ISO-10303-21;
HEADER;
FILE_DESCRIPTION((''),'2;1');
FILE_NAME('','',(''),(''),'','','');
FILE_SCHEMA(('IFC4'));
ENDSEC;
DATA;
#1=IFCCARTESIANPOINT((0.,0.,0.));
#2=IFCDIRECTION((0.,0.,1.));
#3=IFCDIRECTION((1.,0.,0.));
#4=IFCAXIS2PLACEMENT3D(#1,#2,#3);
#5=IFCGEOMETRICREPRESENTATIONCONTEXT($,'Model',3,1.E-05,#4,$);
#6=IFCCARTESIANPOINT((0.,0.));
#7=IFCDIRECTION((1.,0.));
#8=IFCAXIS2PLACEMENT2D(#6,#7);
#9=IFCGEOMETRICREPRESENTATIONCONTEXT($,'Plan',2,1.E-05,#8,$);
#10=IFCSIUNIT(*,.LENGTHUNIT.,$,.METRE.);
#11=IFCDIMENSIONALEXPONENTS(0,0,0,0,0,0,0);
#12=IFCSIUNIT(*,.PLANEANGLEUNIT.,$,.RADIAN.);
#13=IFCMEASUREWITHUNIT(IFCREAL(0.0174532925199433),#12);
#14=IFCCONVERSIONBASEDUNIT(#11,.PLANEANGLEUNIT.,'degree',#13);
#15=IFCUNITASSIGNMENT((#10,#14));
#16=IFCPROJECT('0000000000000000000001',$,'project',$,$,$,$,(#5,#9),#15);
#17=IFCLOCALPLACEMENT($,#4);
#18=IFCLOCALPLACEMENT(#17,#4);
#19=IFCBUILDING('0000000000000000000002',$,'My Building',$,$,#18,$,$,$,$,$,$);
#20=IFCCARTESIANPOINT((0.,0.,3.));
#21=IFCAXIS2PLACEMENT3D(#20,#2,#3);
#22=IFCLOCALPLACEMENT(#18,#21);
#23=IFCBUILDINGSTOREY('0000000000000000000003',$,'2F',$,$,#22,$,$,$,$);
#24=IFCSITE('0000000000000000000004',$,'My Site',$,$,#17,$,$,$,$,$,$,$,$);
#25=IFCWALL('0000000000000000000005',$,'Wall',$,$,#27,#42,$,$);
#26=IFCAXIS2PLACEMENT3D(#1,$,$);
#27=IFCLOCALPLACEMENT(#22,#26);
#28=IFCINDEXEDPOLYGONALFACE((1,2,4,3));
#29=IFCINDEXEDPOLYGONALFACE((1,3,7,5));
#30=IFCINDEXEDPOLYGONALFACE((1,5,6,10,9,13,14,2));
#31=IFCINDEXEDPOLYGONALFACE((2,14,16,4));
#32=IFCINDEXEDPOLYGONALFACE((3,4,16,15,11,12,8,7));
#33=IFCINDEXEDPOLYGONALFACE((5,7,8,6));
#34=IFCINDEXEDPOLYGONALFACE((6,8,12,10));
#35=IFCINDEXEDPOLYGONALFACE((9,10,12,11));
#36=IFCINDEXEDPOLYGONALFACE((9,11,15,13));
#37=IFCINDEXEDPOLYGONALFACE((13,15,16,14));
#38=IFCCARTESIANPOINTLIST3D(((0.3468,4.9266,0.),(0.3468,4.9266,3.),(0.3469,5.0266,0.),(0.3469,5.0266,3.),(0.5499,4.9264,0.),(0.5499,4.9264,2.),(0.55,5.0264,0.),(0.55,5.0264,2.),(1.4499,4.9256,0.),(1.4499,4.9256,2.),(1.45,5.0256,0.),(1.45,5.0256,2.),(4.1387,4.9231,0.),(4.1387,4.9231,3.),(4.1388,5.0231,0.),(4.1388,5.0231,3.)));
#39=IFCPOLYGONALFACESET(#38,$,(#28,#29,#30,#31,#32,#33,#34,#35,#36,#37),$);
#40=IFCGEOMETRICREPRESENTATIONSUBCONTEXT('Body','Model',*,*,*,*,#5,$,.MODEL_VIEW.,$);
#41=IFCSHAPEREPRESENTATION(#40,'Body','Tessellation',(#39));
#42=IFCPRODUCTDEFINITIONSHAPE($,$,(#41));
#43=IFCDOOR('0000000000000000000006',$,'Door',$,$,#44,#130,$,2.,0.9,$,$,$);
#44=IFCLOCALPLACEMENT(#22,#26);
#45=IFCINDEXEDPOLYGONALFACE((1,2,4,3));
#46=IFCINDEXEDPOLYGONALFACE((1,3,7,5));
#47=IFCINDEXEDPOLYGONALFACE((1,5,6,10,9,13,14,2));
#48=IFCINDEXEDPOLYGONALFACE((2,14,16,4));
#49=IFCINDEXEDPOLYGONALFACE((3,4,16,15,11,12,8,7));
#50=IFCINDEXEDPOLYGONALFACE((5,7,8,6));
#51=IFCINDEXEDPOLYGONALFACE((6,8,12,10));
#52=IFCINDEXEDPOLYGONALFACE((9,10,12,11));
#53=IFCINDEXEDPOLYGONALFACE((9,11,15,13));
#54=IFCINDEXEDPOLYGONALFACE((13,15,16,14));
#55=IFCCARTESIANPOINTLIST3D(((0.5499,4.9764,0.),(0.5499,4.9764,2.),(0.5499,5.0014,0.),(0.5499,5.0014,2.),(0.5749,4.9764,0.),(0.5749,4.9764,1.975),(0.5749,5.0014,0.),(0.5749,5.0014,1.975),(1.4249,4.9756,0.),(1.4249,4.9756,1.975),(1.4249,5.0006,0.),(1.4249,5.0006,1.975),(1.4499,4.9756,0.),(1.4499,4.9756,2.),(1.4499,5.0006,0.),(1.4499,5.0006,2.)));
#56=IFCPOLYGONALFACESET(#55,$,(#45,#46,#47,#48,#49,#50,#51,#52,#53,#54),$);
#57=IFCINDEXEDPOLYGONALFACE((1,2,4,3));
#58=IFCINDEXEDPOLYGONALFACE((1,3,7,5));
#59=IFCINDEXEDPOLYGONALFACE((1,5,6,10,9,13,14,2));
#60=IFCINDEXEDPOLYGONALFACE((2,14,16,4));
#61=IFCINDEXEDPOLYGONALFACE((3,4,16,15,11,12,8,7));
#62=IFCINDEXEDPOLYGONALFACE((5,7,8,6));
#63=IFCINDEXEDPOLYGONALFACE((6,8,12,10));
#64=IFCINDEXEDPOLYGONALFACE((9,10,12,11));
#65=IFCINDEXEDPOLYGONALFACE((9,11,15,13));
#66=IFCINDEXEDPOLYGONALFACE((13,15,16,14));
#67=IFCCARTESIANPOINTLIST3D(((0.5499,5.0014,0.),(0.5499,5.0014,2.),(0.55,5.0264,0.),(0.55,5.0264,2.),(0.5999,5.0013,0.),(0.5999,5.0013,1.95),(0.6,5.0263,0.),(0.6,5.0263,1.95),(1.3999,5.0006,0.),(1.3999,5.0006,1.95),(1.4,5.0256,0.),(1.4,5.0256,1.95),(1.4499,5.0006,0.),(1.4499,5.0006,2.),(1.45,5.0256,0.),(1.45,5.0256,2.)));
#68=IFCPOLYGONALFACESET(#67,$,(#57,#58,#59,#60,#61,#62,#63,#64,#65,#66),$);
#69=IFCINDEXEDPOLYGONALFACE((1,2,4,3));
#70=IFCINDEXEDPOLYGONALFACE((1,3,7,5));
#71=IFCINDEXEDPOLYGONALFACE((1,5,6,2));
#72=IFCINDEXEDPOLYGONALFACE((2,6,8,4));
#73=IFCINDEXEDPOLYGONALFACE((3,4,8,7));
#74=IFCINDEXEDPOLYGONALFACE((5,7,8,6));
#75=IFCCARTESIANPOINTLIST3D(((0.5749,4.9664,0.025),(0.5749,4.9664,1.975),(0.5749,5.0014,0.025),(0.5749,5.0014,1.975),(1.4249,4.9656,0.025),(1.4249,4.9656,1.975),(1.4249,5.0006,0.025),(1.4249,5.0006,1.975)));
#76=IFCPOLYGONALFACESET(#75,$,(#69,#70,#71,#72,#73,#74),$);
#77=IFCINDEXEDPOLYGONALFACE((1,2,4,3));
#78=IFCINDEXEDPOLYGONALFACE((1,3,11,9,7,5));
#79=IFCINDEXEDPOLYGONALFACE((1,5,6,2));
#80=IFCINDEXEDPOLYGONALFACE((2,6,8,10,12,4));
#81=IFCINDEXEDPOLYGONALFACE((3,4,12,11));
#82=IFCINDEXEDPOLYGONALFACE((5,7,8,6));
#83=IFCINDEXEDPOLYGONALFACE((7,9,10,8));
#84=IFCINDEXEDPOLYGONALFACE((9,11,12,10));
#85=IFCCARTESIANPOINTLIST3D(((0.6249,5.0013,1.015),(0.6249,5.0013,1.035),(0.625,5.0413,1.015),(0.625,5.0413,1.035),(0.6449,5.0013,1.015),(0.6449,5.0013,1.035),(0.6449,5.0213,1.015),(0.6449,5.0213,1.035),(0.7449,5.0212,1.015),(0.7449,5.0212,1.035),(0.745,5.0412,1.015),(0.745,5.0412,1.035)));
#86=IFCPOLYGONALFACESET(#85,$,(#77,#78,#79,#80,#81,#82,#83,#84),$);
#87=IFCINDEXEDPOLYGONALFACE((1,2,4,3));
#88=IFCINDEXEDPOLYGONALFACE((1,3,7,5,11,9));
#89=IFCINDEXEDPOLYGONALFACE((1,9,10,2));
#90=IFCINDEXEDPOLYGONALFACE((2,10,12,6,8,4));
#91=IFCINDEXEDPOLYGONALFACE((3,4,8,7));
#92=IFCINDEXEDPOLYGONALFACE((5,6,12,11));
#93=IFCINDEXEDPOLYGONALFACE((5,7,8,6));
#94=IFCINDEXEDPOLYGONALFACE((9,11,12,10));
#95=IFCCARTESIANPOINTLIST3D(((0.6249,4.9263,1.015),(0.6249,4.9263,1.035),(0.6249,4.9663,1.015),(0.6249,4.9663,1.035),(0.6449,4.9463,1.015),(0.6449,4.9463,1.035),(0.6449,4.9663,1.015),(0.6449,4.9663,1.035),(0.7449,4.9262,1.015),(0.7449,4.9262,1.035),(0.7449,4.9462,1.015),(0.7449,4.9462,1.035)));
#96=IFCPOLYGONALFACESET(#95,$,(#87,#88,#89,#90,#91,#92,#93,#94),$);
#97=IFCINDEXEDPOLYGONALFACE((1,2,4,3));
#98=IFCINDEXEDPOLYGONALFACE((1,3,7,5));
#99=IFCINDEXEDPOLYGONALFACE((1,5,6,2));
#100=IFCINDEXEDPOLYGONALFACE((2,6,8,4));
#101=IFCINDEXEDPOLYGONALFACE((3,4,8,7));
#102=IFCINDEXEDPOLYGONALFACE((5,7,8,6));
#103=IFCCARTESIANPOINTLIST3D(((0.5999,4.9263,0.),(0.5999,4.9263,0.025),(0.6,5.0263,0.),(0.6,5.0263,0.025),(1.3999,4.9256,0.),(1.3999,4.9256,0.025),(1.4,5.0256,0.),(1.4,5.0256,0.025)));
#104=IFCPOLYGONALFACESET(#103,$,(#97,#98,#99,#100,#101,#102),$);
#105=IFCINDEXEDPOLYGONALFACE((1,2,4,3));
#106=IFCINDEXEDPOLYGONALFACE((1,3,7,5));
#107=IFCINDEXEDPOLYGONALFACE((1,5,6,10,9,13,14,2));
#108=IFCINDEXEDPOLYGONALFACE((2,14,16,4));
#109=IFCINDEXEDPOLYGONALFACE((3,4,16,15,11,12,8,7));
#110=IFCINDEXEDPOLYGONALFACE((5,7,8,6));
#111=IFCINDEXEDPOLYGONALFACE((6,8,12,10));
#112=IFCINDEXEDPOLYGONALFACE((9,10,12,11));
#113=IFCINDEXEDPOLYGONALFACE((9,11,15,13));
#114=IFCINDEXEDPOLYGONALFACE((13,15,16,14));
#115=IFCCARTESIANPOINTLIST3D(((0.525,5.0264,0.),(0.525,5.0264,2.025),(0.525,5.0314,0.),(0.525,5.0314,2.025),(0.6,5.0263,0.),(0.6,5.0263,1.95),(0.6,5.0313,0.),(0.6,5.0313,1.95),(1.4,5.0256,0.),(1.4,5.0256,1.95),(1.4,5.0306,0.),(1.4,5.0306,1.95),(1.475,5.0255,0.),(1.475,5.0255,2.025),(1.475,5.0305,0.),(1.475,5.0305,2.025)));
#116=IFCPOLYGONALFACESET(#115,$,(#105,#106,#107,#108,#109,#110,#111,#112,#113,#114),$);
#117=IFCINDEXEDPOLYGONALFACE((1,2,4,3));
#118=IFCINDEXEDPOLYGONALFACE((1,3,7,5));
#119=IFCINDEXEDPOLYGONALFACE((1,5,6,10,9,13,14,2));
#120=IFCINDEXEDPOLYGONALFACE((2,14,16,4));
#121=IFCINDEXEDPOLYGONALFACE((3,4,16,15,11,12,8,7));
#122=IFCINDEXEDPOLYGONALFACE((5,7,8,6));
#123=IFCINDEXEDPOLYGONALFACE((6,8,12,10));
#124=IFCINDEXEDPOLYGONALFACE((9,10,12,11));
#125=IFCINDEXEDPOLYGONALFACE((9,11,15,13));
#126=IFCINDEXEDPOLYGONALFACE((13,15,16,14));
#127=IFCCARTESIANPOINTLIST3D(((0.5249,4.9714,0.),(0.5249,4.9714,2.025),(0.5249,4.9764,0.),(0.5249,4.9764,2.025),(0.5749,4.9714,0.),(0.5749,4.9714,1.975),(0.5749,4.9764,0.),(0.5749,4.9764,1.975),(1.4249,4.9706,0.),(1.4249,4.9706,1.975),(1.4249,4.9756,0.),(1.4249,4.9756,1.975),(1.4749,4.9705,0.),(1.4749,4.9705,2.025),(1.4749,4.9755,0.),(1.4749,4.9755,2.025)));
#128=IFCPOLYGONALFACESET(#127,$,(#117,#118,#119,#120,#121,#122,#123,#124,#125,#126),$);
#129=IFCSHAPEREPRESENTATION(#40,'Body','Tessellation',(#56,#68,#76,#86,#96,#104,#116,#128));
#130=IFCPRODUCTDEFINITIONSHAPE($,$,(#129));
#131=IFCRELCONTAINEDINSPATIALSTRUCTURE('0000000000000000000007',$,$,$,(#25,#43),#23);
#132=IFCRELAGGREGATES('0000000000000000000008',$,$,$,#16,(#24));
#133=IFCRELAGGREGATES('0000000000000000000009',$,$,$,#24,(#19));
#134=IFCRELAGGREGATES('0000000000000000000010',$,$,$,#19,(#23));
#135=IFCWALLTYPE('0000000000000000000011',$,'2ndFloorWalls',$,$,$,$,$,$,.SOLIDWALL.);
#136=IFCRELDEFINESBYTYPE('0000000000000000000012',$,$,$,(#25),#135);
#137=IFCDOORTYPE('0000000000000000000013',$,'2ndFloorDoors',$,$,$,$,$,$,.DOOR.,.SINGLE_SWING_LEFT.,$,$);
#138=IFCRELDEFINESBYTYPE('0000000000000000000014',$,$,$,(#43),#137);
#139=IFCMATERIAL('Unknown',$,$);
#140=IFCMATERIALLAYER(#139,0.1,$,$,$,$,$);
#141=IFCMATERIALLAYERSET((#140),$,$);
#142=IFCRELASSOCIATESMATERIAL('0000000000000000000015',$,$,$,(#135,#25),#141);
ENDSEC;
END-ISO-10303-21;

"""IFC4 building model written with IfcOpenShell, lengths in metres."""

from ifc_helpers import new_model, entity, si_unit, converted_unit, frame, origin_with_axes, origin_2d_with_axis, place, context, subcontext, project, spatial, line, indexed_curve, outline, extrude, shape, source, transform, mapped, material, layer, layer_set, layer_usage, type_object, type_shapes, element, fill, save


model = new_model("IFC4")

# Units and contexts
model_context = context("Model", 3, precision=1e-05, world=origin_with_axes())
plan_context = context("Plan", 2, precision=1e-05, world=origin_2d_with_axis())
body_context_1 = subcontext(model_context, "Body", "Model", "MODEL_VIEW")
body_context_2 = subcontext(plan_context, "Body", "Plan", "PLAN_VIEW")
ifc_project = project(units=[si_unit("LENGTHUNIT", "METRE"), converted_unit("PLANEANGLEUNIT", "degree", entity("IfcReal", 0.0174532925199433), si_unit("PLANEANGLEUNIT", "RADIAN"), dimensions=[0, 0, 0, 0, 0, 0, 0])], contexts=[model_context, plan_context])

# Site, building, storey
site_placement = place(None, origin_with_axes())
site = spatial("IfcSite", under=ifc_project, at=site_placement, Name="My Site")
building_placement = place(site_placement, origin_with_axes())
building = spatial("IfcBuilding", under=site, at=building_placement, Name="My Building")
storey_placement = place(building_placement, frame((0.0, 0.0, 3.0), z_axis=(0.0, 0.0, 1.0), x_axis=(1.0, 0.0, 0.0)))
storey = spatial("IfcBuildingStorey", under=building, at=storey_placement, Name="2F")

# Shared definitions
ifc_material = material(Name="Unknown")

# Shared definitions
ifc_layer_1 = layer(ifc_material, 0.1)
ifc_layer_set_1 = layer_set([ifc_layer_1])
wall_type = type_object("IfcWallType", Name="2ndFloorWalls", PredefinedType="SOLIDWALL", material=ifc_layer_set_1)

# Shared definitions
shared_shape_1 = source(origin_with_axes(), body_context_1, "Body", "SweptSolid", [
    extrude(outline(indexed_curve([(0.0, 0.0), (0.9, 0.0), (0.9, 2.0), (0.0, 2.0)], segments=[line(1, 2, 3, 4, 1)])), frame((0.0, -0.6, 0.0), z_axis=(0.0, -1.0, 0.0), x_axis=(1.0, 0.0, 0.0)), (0.0, 0.0, -1.0), 1.2),
])
door_type = type_object("IfcDoorType", Name="2ndFloorDoors", OperationType="SINGLE_SWING_LEFT", PredefinedType="DOOR")
shared_shape_2 = source(origin_with_axes(), body_context_1, "Body", "SweptSolid", [
    extrude(outline(indexed_curve([(0.0, 0.0), (0.0, 2.0), (0.9, 2.0), (0.9, 0.0), (0.875, 0.0), (0.875, 1.975), (0.025, 1.975), (0.025, 0.0)], segments=[line(1, 2, 3, 4, 5, 6, 7, 8, 1)])), frame((0.0, 0.025, 0.0), z_axis=(0.0, -1.0, 0.0), x_axis=(1.0, 0.0, 0.0)), (0.0, 0.0, -1.0), 0.025),
    extrude(outline(indexed_curve([(0.0, 0.0), (0.0, 2.0), (0.9, 2.0), (0.9, 0.0), (0.85, 0.0), (0.85, 1.95), (0.05, 1.95), (0.05, 0.0)], segments=[line(1, 2, 3, 4, 5, 6, 7, 8, 1)])), frame((0.0, 0.0, 0.0), z_axis=(0.0, -1.0, 0.0), x_axis=(1.0, 0.0, 0.0)), (0.0, 0.0, -1.0), 0.025),
    extrude(outline(indexed_curve([(0.0, 0.0), (0.85, 0.0), (0.85, 0.035), (0.0, 0.035)], segments=[line(1, 2, 3, 4, 1)])), frame((0.025, 0.025, 0.025), z_axis=(0.0, 0.0, 1.0), x_axis=(1.0, 0.0, 0.0)), (0.0, 0.0, 1.0), 1.95),
    extrude(outline(indexed_curve([(0.0, 0.0), (0.0, -0.04), (-0.12, -0.04), (-0.12, -0.02), (-0.02, -0.02), (-0.02, 0.0)], segments=[line(1, 2, 3, 4, 5, 6, 1)])), frame((0.825, 0.025, 1.015), z_axis=(0.0, 0.0, 1.0), x_axis=(1.0, 0.0, 0.0)), (0.0, 0.0, 1.0), 0.02),
    extrude(outline(indexed_curve([(0.0, 0.0), (0.0, 0.04), (-0.12, 0.04), (-0.12, 0.02), (-0.02, 0.02), (-0.02, 0.0)], segments=[line(1, 2, 3, 4, 5, 6, 1)])), frame((0.825, 0.06, 1.015), z_axis=(0.0, 0.0, 1.0), x_axis=(1.0, 0.0, 0.0)), (0.0, 0.0, 1.0), 0.02),
    extrude(outline(indexed_curve([(0.0, 0.0), (0.8, 0.0), (0.8, 0.1), (0.0, 0.1)], segments=[line(1, 2, 3, 4, 1)])), frame((0.05, 0.0, 0.0), z_axis=(0.0, 0.0, 1.0), x_axis=(1.0, 0.0, 0.0)), (0.0, 0.0, 1.0), 0.025),
    extrude(outline(indexed_curve([(0.0, 0.0), (0.0, 2.025), (0.95, 2.025), (0.95, 0.0), (0.875, 0.0), (0.875, 1.95), (0.075, 1.95), (0.075, 0.0)], segments=[line(1, 2, 3, 4, 5, 6, 7, 8, 1)])), frame((-0.025, -0.005, 0.0), z_axis=(0.0, -1.0, 0.0), x_axis=(1.0, 0.0, 0.0)), (0.0, 0.0, -1.0), 0.005),
    extrude(outline(indexed_curve([(0.0, 0.0), (0.0, 2.025), (0.95, 2.025), (0.95, 0.0), (0.9, 0.0), (0.9, 1.975), (0.05, 1.975), (0.05, 0.0)], segments=[line(1, 2, 3, 4, 5, 6, 7, 8, 1)])), frame((-0.025, 0.05, 0.0), z_axis=(0.0, -1.0, 0.0), x_axis=(1.0, 0.0, 0.0)), (0.0, 0.0, -1.0), 0.005),
])
shared_shape_3 = source(origin_with_axes(), body_context_2, "Body", "Curve2D", [
    entity("IfcIndexedPolyCurve", entity("IfcCartesianPointList2D", [[0.0, 0.0], [0.0, 0.05], [0.025, 0.05], [0.025, 0.025], [0.05, 0.025], [0.05, 0.0]]), [entity("IfcLineIndex", [1, 2, 3, 4, 5, 6, 1])]),
    entity("IfcIndexedPolyCurve", entity("IfcCartesianPointList2D", [[0.9, 0.0], [0.9, 0.05], [0.875, 0.05], [0.875, 0.025], [0.85, 0.025], [0.85, 0.0]]), [entity("IfcLineIndex", [1, 2, 3, 4, 5, 6, 1])]),
    entity("IfcTrimmedCurve", entity("IfcEllipse", entity("IfcAxis2Placement2D", entity("IfcCartesianPoint", [0.06, 0.05]), entity("IfcDirection", [1.0, 0.0])), 0.815, 0.85), [entity("IfcCartesianPoint", [0.875, 0.05])], [entity("IfcCartesianPoint", [0.06, 0.9])], True, "CARTESIAN"),
    entity("IfcIndexedPolyCurve", entity("IfcCartesianPointList2D", [[0.025, 0.05], [0.06, 0.05], [0.06, 0.9], [0.025, 0.9]]), [entity("IfcLineIndex", [1, 2, 3, 4, 1])]),
])
type_shapes(door_type, [shared_shape_2, shared_shape_3])

# Wall, opening, door
ifc_layer_usage_1 = layer_usage(ifc_layer_set_1, "AXIS2", "POSITIVE", 0.0)
wall_1_placement = place(storey_placement, frame((4.1388, 5.0231, 0.0), z_axis=(0.0, 0.0, 1.0), x_axis=(-1.0, 0.000917, 0.0)))
wall_1 = element("IfcWall", 1, at=wall_1_placement, inside=storey, type_object=wall_type, material=ifc_layer_usage_1, Name="Wall", context=body_context_1, shape_type="SweptSolid", body=[
    extrude(outline(indexed_curve([(0.0, 0.0), (0.0, 0.1), (3.7919, 0.1), (3.7919, 0.0)], segments=[line(1, 2, 3, 4, 1)])), origin_with_axes(), (0.0, 0.0, 1.0), 3.0),
])
opening_1_placement = place(wall_1_placement, frame((2.6888, 0.0, 0.0), z_axis=(0.0, 0.0, 1.0), x_axis=(1.0, 0.0, 0.0)))
opening_1 = element("IfcOpeningElement", 2, at=opening_1_placement, cuts=wall_1, PredefinedType="OPENING", context=body_context_1, shape_type="MappedRepresentation", body=[
    mapped(shared_shape_1, transform((0.0, 0.0, 0.0), x_axis=(1.0, 0.0, 0.0), y_axis=(0.0, 1.0, 0.0), z_axis=(0.0, 0.0, 1.0), scale=1.0)),
])
door_1_placement = place(opening_1_placement, frame((0.0, 0.0, 0.0), z_axis=(0.0, 0.0, 1.0), x_axis=(1.0, 0.0, 0.0)))
door_1 = element("IfcDoor", 3, at=door_1_placement, inside=storey, type_object=door_type, Name="Door", OverallHeight=2.0, OverallWidth=0.9, shapes=[
    shape(body_context_1, "Body", "MappedRepresentation", [mapped(shared_shape_2, transform((0.0, 0.0, 0.0), x_axis=(1.0, 0.0, 0.0), y_axis=(0.0, 1.0, 0.0), z_axis=(0.0, 0.0, 1.0), scale=1.0))]),
    shape(body_context_2, "Body", "MappedRepresentation", [mapped(shared_shape_3, transform((0.0, 0.0, 0.0), x_axis=(1.0, 0.0, 0.0), y_axis=(0.0, 1.0, 0.0), z_axis=(0.0, 0.0, 1.0), scale=1.0))]),
])
fill(opening_1, door_1)

save(model, "model.ifc")
